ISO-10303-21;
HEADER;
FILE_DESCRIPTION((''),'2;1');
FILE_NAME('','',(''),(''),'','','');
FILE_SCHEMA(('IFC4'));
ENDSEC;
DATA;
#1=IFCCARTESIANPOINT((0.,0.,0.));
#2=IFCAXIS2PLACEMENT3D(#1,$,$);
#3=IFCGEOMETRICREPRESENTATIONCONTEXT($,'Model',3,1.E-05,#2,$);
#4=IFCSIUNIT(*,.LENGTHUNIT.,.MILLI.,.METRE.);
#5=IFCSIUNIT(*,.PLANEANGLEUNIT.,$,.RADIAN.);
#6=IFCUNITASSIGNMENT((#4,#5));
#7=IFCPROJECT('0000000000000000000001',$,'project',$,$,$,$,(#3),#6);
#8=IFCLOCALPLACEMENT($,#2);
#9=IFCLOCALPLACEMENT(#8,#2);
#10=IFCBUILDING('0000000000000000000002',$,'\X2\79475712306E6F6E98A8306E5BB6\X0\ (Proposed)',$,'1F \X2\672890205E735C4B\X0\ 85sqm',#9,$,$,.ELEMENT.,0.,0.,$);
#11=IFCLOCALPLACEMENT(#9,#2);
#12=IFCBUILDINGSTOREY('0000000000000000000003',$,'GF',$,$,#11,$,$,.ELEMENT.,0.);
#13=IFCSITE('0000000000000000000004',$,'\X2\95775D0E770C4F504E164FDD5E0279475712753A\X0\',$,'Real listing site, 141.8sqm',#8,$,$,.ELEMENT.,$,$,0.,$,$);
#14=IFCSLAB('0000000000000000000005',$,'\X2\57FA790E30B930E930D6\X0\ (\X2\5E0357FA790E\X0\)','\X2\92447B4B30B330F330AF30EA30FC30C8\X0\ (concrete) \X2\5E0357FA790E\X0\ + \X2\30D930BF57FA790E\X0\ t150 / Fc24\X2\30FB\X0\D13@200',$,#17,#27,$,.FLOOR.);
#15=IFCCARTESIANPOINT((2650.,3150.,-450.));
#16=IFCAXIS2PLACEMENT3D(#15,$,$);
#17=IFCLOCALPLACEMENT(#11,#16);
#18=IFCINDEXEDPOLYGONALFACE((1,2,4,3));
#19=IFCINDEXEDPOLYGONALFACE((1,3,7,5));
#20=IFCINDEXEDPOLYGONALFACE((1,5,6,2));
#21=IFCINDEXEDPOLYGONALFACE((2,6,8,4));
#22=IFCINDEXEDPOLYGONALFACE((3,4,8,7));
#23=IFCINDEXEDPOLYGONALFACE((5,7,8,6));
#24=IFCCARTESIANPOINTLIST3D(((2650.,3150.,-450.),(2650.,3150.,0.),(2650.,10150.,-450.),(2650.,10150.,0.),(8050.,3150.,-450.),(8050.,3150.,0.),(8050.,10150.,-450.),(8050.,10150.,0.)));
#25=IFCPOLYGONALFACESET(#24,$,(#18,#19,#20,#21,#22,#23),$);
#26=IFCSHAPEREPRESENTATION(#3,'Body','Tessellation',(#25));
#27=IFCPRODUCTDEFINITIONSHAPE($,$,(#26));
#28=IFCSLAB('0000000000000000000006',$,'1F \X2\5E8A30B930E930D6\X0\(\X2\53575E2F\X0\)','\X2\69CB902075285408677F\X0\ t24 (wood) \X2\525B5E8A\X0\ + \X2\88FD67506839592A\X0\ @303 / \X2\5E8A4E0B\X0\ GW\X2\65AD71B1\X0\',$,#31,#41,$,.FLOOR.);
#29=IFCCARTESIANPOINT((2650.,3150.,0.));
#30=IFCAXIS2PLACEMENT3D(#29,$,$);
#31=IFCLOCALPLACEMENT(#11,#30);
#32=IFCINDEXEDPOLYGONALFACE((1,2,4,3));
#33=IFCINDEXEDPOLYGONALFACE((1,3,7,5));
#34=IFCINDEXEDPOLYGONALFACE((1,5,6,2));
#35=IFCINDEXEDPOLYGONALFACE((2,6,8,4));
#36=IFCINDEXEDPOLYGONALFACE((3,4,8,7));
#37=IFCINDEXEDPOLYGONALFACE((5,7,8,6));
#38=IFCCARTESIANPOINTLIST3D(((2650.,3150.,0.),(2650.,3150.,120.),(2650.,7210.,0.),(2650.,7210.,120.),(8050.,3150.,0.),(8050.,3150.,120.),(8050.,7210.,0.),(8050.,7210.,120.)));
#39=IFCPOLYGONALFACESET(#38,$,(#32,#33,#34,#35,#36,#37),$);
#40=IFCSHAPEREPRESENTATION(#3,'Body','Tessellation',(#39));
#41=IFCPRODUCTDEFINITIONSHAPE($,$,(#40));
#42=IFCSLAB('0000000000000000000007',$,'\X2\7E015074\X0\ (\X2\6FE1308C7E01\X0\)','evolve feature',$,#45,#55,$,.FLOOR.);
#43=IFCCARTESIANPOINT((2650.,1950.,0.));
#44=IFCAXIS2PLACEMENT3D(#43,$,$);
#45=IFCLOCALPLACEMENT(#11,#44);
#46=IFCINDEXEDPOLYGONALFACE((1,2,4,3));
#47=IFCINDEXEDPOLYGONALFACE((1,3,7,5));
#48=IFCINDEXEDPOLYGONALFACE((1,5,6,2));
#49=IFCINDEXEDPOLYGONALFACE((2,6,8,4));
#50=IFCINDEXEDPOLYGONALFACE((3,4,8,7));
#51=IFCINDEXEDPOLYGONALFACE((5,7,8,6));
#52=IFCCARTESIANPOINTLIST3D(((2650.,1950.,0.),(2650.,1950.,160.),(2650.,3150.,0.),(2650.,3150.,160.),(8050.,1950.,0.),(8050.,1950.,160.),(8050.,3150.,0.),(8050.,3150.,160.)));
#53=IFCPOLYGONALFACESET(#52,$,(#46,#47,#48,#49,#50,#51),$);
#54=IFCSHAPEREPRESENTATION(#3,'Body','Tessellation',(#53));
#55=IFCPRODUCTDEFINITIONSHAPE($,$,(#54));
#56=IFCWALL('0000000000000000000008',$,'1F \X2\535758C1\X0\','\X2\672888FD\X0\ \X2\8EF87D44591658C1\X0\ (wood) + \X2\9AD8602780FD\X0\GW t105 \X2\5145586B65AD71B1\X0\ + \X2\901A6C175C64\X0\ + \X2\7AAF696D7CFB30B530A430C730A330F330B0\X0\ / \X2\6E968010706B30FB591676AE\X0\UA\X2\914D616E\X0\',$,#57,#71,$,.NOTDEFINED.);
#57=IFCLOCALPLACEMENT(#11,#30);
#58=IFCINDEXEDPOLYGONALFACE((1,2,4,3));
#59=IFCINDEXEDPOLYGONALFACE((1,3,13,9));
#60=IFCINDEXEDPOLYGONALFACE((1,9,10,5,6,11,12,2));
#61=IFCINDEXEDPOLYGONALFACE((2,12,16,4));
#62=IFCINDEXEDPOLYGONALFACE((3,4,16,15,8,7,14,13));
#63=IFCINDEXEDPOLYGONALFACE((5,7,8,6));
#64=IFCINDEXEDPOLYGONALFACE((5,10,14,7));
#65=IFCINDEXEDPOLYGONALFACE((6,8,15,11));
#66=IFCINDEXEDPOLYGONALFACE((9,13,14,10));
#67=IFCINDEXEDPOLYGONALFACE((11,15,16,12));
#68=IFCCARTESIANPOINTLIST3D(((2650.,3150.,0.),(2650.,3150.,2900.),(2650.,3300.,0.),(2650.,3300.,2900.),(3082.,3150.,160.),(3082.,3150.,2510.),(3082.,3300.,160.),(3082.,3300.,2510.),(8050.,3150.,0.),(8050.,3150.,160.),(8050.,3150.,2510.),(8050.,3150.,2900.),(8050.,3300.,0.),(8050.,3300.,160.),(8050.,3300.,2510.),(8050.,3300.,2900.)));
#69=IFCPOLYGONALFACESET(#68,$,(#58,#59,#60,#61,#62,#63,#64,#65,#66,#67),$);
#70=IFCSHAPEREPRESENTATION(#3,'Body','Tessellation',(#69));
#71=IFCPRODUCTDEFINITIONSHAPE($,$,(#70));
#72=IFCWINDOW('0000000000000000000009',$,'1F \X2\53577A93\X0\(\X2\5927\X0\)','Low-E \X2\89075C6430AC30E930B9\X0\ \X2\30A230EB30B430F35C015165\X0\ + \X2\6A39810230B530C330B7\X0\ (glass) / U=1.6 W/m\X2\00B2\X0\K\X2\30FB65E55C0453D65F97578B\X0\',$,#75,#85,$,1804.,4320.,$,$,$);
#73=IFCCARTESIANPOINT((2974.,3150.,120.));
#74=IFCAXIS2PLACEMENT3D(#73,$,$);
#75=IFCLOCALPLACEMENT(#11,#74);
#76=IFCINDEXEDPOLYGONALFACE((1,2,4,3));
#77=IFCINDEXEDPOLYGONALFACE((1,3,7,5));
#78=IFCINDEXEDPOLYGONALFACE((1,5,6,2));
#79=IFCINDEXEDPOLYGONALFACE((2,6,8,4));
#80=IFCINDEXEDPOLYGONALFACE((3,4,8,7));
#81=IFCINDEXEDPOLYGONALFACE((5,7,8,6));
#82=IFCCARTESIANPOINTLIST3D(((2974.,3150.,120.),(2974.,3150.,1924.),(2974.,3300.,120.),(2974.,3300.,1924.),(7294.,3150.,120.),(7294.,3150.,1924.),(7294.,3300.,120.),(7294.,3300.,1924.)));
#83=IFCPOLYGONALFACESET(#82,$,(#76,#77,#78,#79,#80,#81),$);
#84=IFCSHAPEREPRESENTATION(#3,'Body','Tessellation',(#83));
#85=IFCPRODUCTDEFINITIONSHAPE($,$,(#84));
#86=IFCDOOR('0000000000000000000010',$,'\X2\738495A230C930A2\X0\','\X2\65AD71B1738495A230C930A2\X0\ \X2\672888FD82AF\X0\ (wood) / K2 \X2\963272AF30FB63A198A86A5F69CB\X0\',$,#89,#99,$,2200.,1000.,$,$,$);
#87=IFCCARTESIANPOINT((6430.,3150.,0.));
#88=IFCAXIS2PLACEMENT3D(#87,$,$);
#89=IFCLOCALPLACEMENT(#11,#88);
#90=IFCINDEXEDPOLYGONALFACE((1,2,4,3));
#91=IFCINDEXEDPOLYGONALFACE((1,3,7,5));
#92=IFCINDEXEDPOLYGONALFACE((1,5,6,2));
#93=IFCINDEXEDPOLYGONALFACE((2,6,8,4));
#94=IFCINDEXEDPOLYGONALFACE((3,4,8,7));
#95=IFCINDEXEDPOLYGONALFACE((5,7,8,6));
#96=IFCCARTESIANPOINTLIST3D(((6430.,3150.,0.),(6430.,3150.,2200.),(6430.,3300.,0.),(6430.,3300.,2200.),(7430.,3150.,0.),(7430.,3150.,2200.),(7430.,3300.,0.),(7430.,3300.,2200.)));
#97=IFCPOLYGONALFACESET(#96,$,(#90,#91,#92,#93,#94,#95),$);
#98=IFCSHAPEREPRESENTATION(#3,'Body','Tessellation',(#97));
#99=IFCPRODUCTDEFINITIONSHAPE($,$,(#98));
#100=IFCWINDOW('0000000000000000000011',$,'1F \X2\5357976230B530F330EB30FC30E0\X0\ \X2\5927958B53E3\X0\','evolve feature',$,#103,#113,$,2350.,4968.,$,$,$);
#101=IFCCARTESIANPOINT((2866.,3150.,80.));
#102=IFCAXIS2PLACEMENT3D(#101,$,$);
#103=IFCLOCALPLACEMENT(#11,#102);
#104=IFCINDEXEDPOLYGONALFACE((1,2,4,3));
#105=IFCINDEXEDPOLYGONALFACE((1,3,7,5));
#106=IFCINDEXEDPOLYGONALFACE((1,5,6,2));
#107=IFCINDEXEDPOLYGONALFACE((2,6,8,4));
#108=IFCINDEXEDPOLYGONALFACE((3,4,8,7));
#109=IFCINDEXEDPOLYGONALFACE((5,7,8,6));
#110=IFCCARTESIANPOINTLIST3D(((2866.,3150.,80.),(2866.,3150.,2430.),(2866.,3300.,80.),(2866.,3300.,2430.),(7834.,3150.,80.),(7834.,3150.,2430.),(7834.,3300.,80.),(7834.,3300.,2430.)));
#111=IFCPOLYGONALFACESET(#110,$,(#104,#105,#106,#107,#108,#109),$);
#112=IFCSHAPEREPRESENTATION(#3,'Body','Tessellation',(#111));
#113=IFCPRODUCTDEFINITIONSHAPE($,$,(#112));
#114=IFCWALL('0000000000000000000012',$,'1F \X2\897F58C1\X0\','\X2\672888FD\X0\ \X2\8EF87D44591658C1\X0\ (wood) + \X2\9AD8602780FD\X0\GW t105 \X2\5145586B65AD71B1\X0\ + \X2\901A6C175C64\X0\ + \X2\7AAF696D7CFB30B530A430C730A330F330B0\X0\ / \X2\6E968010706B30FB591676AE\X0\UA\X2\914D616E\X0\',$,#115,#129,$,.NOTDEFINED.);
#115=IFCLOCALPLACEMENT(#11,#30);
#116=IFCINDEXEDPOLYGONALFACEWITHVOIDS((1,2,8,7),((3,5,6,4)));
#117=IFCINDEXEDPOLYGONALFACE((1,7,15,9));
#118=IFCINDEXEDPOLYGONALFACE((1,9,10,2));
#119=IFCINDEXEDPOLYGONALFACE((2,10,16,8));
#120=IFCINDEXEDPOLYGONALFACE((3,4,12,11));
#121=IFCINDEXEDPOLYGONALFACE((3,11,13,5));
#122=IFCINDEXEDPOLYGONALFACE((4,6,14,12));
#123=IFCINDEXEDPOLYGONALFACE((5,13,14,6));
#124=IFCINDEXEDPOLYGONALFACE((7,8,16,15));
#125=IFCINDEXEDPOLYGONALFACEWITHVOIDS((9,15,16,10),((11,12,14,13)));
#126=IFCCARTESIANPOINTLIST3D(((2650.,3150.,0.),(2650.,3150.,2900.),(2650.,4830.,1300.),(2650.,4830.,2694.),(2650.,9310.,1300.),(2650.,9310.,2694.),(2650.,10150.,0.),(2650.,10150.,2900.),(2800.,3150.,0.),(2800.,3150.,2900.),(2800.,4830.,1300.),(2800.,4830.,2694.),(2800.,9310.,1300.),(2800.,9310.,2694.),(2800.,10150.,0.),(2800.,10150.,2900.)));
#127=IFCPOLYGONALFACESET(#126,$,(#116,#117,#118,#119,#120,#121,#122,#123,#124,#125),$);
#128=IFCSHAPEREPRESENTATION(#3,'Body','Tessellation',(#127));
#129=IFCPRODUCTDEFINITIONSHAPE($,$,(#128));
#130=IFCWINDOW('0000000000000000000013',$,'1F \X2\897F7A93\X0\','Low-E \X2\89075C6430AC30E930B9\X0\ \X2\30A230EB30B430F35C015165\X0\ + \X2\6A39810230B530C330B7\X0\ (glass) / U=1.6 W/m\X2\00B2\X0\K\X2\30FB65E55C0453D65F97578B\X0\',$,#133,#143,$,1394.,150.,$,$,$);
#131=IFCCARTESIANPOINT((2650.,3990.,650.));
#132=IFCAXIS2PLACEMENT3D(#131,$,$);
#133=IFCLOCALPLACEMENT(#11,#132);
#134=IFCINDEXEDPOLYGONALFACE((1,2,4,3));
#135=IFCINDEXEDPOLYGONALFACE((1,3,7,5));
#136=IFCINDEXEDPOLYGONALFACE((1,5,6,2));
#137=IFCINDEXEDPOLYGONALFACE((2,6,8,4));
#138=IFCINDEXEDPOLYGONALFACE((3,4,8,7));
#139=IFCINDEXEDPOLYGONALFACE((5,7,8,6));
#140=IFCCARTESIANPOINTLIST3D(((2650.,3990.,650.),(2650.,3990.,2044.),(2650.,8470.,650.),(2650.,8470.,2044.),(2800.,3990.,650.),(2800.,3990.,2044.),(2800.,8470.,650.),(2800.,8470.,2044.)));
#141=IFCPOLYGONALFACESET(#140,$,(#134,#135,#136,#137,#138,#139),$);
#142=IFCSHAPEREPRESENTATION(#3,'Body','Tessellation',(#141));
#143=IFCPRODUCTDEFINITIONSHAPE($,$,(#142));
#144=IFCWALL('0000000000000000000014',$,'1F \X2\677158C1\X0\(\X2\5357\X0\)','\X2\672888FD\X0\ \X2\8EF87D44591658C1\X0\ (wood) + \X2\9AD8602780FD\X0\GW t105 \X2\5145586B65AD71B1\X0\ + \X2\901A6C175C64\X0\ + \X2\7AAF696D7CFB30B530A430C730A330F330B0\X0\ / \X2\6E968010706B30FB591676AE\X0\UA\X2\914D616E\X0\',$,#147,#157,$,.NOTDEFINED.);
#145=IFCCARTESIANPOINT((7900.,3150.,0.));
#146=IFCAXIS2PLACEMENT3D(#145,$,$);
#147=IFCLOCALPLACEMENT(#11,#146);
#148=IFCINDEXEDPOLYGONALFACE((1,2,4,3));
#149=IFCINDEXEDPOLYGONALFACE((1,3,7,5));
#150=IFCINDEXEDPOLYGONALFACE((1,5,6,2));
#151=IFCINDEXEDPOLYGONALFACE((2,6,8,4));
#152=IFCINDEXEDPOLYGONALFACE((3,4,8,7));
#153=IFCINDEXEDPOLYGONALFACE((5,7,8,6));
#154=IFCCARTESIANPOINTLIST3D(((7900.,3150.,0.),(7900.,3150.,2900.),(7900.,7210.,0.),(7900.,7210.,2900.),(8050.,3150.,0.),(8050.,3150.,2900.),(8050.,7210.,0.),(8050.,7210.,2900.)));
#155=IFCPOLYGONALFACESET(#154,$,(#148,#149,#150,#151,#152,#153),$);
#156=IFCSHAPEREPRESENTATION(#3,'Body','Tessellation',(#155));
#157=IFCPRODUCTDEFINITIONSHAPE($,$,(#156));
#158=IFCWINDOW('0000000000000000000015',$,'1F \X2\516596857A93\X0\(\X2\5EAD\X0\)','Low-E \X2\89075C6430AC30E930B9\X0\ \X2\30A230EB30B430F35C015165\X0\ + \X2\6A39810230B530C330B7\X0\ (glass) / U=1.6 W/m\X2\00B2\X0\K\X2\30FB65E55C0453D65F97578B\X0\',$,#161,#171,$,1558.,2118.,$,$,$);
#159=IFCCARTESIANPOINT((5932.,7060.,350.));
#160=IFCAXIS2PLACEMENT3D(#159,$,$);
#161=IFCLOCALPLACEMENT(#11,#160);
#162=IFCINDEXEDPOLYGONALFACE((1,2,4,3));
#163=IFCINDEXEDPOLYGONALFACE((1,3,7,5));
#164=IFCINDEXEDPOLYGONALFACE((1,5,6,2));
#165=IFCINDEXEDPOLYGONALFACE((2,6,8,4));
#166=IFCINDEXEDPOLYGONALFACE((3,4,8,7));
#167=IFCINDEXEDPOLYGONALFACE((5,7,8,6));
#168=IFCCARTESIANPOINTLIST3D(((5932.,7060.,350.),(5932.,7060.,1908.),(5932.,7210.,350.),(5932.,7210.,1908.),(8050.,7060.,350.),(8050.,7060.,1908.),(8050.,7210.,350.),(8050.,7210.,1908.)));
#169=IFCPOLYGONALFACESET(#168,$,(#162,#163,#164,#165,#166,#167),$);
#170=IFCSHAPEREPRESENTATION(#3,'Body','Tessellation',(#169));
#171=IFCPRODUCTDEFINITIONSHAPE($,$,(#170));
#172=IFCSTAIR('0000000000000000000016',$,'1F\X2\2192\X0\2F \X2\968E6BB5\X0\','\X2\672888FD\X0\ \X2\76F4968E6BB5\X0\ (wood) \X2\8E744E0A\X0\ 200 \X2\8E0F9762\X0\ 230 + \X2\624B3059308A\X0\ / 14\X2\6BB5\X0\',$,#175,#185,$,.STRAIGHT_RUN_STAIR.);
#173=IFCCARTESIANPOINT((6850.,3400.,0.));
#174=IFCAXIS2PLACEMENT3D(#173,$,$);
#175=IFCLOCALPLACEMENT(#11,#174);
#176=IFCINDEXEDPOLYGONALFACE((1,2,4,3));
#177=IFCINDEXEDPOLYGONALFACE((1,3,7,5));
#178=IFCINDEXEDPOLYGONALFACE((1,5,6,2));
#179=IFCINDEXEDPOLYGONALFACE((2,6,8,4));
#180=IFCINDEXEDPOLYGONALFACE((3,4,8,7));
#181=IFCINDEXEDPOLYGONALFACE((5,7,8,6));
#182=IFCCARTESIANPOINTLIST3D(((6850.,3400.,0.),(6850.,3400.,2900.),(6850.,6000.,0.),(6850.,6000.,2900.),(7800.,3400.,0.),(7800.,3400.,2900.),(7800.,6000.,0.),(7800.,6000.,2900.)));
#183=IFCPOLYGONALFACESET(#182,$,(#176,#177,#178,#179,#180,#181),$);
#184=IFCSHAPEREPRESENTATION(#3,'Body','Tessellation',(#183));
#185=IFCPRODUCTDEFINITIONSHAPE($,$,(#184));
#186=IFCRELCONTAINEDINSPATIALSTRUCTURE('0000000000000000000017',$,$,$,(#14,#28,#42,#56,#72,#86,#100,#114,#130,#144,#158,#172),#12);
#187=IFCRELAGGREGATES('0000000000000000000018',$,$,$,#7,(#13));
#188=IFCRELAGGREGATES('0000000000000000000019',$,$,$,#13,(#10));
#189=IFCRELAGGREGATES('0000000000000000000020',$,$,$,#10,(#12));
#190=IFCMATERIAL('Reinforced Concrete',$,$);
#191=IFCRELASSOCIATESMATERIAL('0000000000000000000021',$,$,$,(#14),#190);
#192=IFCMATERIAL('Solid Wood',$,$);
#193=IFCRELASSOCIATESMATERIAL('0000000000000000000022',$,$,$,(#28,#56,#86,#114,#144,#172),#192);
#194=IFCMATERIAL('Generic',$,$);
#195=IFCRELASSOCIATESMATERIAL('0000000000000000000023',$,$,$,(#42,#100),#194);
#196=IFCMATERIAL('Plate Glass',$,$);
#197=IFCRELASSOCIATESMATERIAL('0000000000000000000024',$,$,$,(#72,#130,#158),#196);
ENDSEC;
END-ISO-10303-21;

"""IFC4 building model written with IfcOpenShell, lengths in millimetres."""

from ifc_helpers import new_model, si_unit, frame, frame_2d, origin, place, context, project, spatial, rectangle, extrude, material, element, fill, save


model = new_model("IFC4")

# Units and contexts
model_context = context("Model", 3, precision=1e-05, world=origin())
ifc_project = project(units=[si_unit("LENGTHUNIT", "METRE", prefix="MILLI"), si_unit("PLANEANGLEUNIT", "RADIAN")], contexts=[model_context])

# Site, building, storey
site_placement = place(None, origin())
site = spatial("IfcSite", under=ifc_project, at=site_placement, Name="長崎県佐世保市祇園町", ObjectType="Real listing site, 141.8sqm", CompositionType="ELEMENT", RefElevation=0.0)
building_placement = place(site_placement, origin())
building = spatial("IfcBuilding", under=site, at=building_placement, Name="祇園の潮風の家 (Proposed)", ObjectType="1F 木造平屋 85sqm", CompositionType="ELEMENT", ElevationOfRefHeight=0.0, ElevationOfTerrain=0.0)
storey_placement = place(building_placement, origin())
storey = spatial("IfcBuildingStorey", under=building, at=storey_placement, Name="GF", CompositionType="ELEMENT", Elevation=0.0)

# Slabs
ifc_material_1 = material(Name="Reinforced Concrete")
slab_1_placement = place(storey_placement, frame((2650.0, 3150.0, -450.0)))
element("IfcSlab", 1, at=slab_1_placement, inside=storey, material=ifc_material_1, Name="基礎スラブ (布基礎)", Description="鉄筋コンクリート (concrete) 布基礎 + ベタ基礎 t150 / Fc24・D13@200", PredefinedType="FLOOR", context=model_context, shape_type="SweptSolid", body=[
    extrude(rectangle(XDim=5400.0, YDim=7000.0, at=frame_2d((2700.0, 3500.0))), frame((2650.0, 3150.0, -450.0)), (0.0, 0.0, 1.0), 450.0),
])
ifc_material_2 = material(Name="Solid Wood")
slab_2_placement = place(storey_placement, frame((2650.0, 3150.0, 0.0)))
element("IfcSlab", 2, at=slab_2_placement, inside=storey, material=ifc_material_2, Name="1F 床スラブ(南帯)", Description="構造用合板 t24 (wood) 剛床 + 製材根太 @303 / 床下 GW断熱", PredefinedType="FLOOR", context=model_context, shape_type="SweptSolid", body=[
    extrude(rectangle(XDim=5400.0, YDim=4060.0, at=frame_2d((2700.0, 2030.0))), frame((2650.0, 3150.0, 0.0)), (0.0, 0.0, 1.0), 120.0),
])
ifc_material_3 = material(Name="Generic")
slab_3_placement = place(storey_placement, frame((2650.0, 1950.0, 0.0)))
element("IfcSlab", 3, at=slab_3_placement, inside=storey, material=ifc_material_3, Name="縁側 (濡れ縁)", Description="evolve feature", PredefinedType="FLOOR", context=model_context, shape_type="SweptSolid", body=[
    extrude(rectangle(XDim=5400.0, YDim=1200.0, at=frame_2d((2700.0, 600.0))), frame((2650.0, 1950.0, 0.0)), (0.0, 0.0, 1.0), 160.0),
])

# Wall, openings, windows, door
wall_1_placement = place(storey_placement, frame((2650.0, 3150.0, 0.0)))
wall_1 = element("IfcWall", 4, at=wall_1_placement, inside=storey, material=ifc_material_2, Name="1F 南壁", Description="木製 軸組外壁 (wood) + 高性能GW t105 充填断熱 + 通気層 + 窯業系サイディング / 準耐火・外皮UA配慮", PredefinedType="NOTDEFINED", context=model_context, shape_type="SweptSolid", body=[
    extrude(rectangle(XDim=5400.0, YDim=150.0, at=frame_2d((2700.0, 75.0))), frame((2650.0, 3150.0, 0.0)), (0.0, 0.0, 1.0), 2900.0),
])
opening_1_placement = place(storey_placement, frame((2974.0, 3150.0, 120.0)))
opening_1 = element("IfcOpeningElement", 5, at=opening_1_placement, cuts=wall_1, PredefinedType="NOTDEFINED", context=model_context, shape_type="SweptSolid", body=[
    extrude(rectangle(XDim=4320.0, YDim=150.0, at=frame_2d((2160.0, 75.0))), frame((2974.0, 3150.0, 120.0)), (0.0, 0.0, 1.0), 1804.0),
])
opening_2_placement = place(storey_placement, frame((6430.0, 3150.0, 0.0)))
opening_2 = element("IfcOpeningElement", 6, at=opening_2_placement, cuts=wall_1, PredefinedType="NOTDEFINED", context=model_context, shape_type="SweptSolid", body=[
    extrude(rectangle(XDim=1000.0, YDim=150.0, at=frame_2d((500.0, 75.0))), frame((6430.0, 3150.0, 0.0)), (0.0, 0.0, 1.0), 2200.0),
])
opening_3_placement = place(storey_placement, frame((2866.0, 3150.0, 80.0)))
opening_3 = element("IfcOpeningElement", 7, at=opening_3_placement, cuts=wall_1, PredefinedType="NOTDEFINED", context=model_context, shape_type="SweptSolid", body=[
    extrude(rectangle(XDim=4968.0, YDim=150.0, at=frame_2d((2484.0, 75.0))), frame((2866.0, 3150.0, 80.0)), (0.0, 0.0, 1.0), 2350.0),
])
ifc_material_4 = material(Name="Plate Glass")
window_1_placement = place(storey_placement, frame((2974.0, 3150.0, 120.0)))
window_1 = element("IfcWindow", 8, at=window_1_placement, inside=storey, material=ifc_material_4, Name="1F 南窓(大)", Description="Low-E 複層ガラス アルゴン封入 + 樹脂サッシ (glass) / U=1.6 W/m²K・日射取得型", OverallHeight=1804.0, OverallWidth=4320.0, context=model_context, shape_type="SweptSolid", body=[
    extrude(rectangle(XDim=4320.0, YDim=150.0, at=frame_2d((2160.0, 75.0))), frame((2974.0, 3150.0, 120.0)), (0.0, 0.0, 1.0), 1804.0),
])
fill(opening_1, window_1)
door_1_placement = place(storey_placement, frame((6430.0, 3150.0, 0.0)))
door_1 = element("IfcDoor", 9, at=door_1_placement, inside=storey, material=ifc_material_2, Name="玄関ドア", Description="断熱玄関ドア 木製芯 (wood) / K2 防犯・採風機構", OverallHeight=2200.0, OverallWidth=1000.0, context=model_context, shape_type="SweptSolid", body=[
    extrude(rectangle(XDim=1000.0, YDim=150.0, at=frame_2d((500.0, 75.0))), frame((6430.0, 3150.0, 0.0)), (0.0, 0.0, 1.0), 2200.0),
])
fill(opening_2, door_1)
window_2_placement = place(storey_placement, frame((2866.0, 3150.0, 80.0)))
window_2 = element("IfcWindow", 10, at=window_2_placement, inside=storey, material=ifc_material_3, Name="1F 南面サンルーム 大開口", Description="evolve feature", OverallHeight=2350.0, OverallWidth=4968.0, context=model_context, shape_type="SweptSolid", body=[
    extrude(rectangle(XDim=4968.0, YDim=150.0, at=frame_2d((2484.0, 75.0))), frame((2866.0, 3150.0, 80.0)), (0.0, 0.0, 1.0), 2350.0),
])
fill(opening_3, window_2)

# Walls, openings, windows
wall_2_placement = place(storey_placement, frame((2650.0, 3150.0, 0.0)))
wall_2 = element("IfcWall", 11, at=wall_2_placement, inside=storey, material=ifc_material_2, Name="1F 西壁", Description="木製 軸組外壁 (wood) + 高性能GW t105 充填断熱 + 通気層 + 窯業系サイディング / 準耐火・外皮UA配慮", PredefinedType="NOTDEFINED", context=model_context, shape_type="SweptSolid", body=[
    extrude(rectangle(XDim=150.0, YDim=7000.0, at=frame_2d((75.0, 3500.0))), frame((2650.0, 3150.0, 0.0)), (0.0, 0.0, 1.0), 2900.0),
])
opening_4_placement = place(storey_placement, frame((2650.0, 3990.0, 650.0)))
opening_4 = element("IfcOpeningElement", 12, at=opening_4_placement, cuts=wall_2, PredefinedType="NOTDEFINED", context=model_context, shape_type="SweptSolid", body=[
    extrude(rectangle(XDim=150.0, YDim=4480.0, at=frame_2d((75.0, 2240.0))), frame((2650.0, 3990.0, 650.0)), (0.0, 0.0, 1.0), 1394.0),
])
window_3_placement = place(storey_placement, frame((2650.0, 3990.0, 650.0)))
window_3 = element("IfcWindow", 13, at=window_3_placement, inside=storey, material=ifc_material_4, Name="1F 西窓", Description="Low-E 複層ガラス アルゴン封入 + 樹脂サッシ (glass) / U=1.6 W/m²K・日射取得型", OverallHeight=1394.0, OverallWidth=150.0, context=model_context, shape_type="SweptSolid", body=[
    extrude(rectangle(XDim=150.0, YDim=4480.0, at=frame_2d((75.0, 2240.0))), frame((2650.0, 3990.0, 650.0)), (0.0, 0.0, 1.0), 1394.0),
])
fill(opening_4, window_3)
wall_3_placement = place(storey_placement, frame((7900.0, 3150.0, 0.0)))
wall_3 = element("IfcWall", 14, at=wall_3_placement, inside=storey, material=ifc_material_2, Name="1F 東壁(南)", Description="木製 軸組外壁 (wood) + 高性能GW t105 充填断熱 + 通気層 + 窯業系サイディング / 準耐火・外皮UA配慮", PredefinedType="NOTDEFINED", context=model_context, shape_type="SweptSolid", body=[
    extrude(rectangle(XDim=150.0, YDim=4060.0, at=frame_2d((75.0, 2030.0))), frame((7900.0, 3150.0, 0.0)), (0.0, 0.0, 1.0), 2900.0),
])
opening_5_placement = place(storey_placement, frame((5932.0, 7060.0, 350.0)))
opening_5 = element("IfcOpeningElement", 15, at=opening_5_placement, cuts=wall_3, PredefinedType="NOTDEFINED", context=model_context, shape_type="SweptSolid", body=[
    extrude(rectangle(XDim=2118.0, YDim=150.0, at=frame_2d((1059.0, 75.0))), frame((5932.0, 7060.0, 350.0)), (0.0, 0.0, 1.0), 1558.0),
])
window_4_placement = place(storey_placement, frame((5932.0, 7060.0, 350.0)))
window_4 = element("IfcWindow", 16, at=window_4_placement, inside=storey, material=ifc_material_4, Name="1F 入隅窓(庭)", Description="Low-E 複層ガラス アルゴン封入 + 樹脂サッシ (glass) / U=1.6 W/m²K・日射取得型", OverallHeight=1558.0, OverallWidth=2118.0, context=model_context, shape_type="SweptSolid", body=[
    extrude(rectangle(XDim=2118.0, YDim=150.0, at=frame_2d((1059.0, 75.0))), frame((5932.0, 7060.0, 350.0)), (0.0, 0.0, 1.0), 1558.0),
])
fill(opening_5, window_4)

# Stair
stair_placement = place(storey_placement, frame((6850.0, 3400.0, 0.0)))
element("IfcStair", 17, at=stair_placement, inside=storey, material=ifc_material_2, Name="1F→2F 階段", Description="木製 直階段 (wood) 蹴上 200 踏面 230 + 手すり / 14段", PredefinedType="STRAIGHT_RUN_STAIR", context=model_context, shape_type="SweptSolid", body=[
    extrude(rectangle(XDim=950.0, YDim=2600.0, at=frame_2d((475.0, 1300.0))), frame((6850.0, 3400.0, 0.0)), (0.0, 0.0, 1.0), 2900.0),
])

save(model, "model.ifc")
